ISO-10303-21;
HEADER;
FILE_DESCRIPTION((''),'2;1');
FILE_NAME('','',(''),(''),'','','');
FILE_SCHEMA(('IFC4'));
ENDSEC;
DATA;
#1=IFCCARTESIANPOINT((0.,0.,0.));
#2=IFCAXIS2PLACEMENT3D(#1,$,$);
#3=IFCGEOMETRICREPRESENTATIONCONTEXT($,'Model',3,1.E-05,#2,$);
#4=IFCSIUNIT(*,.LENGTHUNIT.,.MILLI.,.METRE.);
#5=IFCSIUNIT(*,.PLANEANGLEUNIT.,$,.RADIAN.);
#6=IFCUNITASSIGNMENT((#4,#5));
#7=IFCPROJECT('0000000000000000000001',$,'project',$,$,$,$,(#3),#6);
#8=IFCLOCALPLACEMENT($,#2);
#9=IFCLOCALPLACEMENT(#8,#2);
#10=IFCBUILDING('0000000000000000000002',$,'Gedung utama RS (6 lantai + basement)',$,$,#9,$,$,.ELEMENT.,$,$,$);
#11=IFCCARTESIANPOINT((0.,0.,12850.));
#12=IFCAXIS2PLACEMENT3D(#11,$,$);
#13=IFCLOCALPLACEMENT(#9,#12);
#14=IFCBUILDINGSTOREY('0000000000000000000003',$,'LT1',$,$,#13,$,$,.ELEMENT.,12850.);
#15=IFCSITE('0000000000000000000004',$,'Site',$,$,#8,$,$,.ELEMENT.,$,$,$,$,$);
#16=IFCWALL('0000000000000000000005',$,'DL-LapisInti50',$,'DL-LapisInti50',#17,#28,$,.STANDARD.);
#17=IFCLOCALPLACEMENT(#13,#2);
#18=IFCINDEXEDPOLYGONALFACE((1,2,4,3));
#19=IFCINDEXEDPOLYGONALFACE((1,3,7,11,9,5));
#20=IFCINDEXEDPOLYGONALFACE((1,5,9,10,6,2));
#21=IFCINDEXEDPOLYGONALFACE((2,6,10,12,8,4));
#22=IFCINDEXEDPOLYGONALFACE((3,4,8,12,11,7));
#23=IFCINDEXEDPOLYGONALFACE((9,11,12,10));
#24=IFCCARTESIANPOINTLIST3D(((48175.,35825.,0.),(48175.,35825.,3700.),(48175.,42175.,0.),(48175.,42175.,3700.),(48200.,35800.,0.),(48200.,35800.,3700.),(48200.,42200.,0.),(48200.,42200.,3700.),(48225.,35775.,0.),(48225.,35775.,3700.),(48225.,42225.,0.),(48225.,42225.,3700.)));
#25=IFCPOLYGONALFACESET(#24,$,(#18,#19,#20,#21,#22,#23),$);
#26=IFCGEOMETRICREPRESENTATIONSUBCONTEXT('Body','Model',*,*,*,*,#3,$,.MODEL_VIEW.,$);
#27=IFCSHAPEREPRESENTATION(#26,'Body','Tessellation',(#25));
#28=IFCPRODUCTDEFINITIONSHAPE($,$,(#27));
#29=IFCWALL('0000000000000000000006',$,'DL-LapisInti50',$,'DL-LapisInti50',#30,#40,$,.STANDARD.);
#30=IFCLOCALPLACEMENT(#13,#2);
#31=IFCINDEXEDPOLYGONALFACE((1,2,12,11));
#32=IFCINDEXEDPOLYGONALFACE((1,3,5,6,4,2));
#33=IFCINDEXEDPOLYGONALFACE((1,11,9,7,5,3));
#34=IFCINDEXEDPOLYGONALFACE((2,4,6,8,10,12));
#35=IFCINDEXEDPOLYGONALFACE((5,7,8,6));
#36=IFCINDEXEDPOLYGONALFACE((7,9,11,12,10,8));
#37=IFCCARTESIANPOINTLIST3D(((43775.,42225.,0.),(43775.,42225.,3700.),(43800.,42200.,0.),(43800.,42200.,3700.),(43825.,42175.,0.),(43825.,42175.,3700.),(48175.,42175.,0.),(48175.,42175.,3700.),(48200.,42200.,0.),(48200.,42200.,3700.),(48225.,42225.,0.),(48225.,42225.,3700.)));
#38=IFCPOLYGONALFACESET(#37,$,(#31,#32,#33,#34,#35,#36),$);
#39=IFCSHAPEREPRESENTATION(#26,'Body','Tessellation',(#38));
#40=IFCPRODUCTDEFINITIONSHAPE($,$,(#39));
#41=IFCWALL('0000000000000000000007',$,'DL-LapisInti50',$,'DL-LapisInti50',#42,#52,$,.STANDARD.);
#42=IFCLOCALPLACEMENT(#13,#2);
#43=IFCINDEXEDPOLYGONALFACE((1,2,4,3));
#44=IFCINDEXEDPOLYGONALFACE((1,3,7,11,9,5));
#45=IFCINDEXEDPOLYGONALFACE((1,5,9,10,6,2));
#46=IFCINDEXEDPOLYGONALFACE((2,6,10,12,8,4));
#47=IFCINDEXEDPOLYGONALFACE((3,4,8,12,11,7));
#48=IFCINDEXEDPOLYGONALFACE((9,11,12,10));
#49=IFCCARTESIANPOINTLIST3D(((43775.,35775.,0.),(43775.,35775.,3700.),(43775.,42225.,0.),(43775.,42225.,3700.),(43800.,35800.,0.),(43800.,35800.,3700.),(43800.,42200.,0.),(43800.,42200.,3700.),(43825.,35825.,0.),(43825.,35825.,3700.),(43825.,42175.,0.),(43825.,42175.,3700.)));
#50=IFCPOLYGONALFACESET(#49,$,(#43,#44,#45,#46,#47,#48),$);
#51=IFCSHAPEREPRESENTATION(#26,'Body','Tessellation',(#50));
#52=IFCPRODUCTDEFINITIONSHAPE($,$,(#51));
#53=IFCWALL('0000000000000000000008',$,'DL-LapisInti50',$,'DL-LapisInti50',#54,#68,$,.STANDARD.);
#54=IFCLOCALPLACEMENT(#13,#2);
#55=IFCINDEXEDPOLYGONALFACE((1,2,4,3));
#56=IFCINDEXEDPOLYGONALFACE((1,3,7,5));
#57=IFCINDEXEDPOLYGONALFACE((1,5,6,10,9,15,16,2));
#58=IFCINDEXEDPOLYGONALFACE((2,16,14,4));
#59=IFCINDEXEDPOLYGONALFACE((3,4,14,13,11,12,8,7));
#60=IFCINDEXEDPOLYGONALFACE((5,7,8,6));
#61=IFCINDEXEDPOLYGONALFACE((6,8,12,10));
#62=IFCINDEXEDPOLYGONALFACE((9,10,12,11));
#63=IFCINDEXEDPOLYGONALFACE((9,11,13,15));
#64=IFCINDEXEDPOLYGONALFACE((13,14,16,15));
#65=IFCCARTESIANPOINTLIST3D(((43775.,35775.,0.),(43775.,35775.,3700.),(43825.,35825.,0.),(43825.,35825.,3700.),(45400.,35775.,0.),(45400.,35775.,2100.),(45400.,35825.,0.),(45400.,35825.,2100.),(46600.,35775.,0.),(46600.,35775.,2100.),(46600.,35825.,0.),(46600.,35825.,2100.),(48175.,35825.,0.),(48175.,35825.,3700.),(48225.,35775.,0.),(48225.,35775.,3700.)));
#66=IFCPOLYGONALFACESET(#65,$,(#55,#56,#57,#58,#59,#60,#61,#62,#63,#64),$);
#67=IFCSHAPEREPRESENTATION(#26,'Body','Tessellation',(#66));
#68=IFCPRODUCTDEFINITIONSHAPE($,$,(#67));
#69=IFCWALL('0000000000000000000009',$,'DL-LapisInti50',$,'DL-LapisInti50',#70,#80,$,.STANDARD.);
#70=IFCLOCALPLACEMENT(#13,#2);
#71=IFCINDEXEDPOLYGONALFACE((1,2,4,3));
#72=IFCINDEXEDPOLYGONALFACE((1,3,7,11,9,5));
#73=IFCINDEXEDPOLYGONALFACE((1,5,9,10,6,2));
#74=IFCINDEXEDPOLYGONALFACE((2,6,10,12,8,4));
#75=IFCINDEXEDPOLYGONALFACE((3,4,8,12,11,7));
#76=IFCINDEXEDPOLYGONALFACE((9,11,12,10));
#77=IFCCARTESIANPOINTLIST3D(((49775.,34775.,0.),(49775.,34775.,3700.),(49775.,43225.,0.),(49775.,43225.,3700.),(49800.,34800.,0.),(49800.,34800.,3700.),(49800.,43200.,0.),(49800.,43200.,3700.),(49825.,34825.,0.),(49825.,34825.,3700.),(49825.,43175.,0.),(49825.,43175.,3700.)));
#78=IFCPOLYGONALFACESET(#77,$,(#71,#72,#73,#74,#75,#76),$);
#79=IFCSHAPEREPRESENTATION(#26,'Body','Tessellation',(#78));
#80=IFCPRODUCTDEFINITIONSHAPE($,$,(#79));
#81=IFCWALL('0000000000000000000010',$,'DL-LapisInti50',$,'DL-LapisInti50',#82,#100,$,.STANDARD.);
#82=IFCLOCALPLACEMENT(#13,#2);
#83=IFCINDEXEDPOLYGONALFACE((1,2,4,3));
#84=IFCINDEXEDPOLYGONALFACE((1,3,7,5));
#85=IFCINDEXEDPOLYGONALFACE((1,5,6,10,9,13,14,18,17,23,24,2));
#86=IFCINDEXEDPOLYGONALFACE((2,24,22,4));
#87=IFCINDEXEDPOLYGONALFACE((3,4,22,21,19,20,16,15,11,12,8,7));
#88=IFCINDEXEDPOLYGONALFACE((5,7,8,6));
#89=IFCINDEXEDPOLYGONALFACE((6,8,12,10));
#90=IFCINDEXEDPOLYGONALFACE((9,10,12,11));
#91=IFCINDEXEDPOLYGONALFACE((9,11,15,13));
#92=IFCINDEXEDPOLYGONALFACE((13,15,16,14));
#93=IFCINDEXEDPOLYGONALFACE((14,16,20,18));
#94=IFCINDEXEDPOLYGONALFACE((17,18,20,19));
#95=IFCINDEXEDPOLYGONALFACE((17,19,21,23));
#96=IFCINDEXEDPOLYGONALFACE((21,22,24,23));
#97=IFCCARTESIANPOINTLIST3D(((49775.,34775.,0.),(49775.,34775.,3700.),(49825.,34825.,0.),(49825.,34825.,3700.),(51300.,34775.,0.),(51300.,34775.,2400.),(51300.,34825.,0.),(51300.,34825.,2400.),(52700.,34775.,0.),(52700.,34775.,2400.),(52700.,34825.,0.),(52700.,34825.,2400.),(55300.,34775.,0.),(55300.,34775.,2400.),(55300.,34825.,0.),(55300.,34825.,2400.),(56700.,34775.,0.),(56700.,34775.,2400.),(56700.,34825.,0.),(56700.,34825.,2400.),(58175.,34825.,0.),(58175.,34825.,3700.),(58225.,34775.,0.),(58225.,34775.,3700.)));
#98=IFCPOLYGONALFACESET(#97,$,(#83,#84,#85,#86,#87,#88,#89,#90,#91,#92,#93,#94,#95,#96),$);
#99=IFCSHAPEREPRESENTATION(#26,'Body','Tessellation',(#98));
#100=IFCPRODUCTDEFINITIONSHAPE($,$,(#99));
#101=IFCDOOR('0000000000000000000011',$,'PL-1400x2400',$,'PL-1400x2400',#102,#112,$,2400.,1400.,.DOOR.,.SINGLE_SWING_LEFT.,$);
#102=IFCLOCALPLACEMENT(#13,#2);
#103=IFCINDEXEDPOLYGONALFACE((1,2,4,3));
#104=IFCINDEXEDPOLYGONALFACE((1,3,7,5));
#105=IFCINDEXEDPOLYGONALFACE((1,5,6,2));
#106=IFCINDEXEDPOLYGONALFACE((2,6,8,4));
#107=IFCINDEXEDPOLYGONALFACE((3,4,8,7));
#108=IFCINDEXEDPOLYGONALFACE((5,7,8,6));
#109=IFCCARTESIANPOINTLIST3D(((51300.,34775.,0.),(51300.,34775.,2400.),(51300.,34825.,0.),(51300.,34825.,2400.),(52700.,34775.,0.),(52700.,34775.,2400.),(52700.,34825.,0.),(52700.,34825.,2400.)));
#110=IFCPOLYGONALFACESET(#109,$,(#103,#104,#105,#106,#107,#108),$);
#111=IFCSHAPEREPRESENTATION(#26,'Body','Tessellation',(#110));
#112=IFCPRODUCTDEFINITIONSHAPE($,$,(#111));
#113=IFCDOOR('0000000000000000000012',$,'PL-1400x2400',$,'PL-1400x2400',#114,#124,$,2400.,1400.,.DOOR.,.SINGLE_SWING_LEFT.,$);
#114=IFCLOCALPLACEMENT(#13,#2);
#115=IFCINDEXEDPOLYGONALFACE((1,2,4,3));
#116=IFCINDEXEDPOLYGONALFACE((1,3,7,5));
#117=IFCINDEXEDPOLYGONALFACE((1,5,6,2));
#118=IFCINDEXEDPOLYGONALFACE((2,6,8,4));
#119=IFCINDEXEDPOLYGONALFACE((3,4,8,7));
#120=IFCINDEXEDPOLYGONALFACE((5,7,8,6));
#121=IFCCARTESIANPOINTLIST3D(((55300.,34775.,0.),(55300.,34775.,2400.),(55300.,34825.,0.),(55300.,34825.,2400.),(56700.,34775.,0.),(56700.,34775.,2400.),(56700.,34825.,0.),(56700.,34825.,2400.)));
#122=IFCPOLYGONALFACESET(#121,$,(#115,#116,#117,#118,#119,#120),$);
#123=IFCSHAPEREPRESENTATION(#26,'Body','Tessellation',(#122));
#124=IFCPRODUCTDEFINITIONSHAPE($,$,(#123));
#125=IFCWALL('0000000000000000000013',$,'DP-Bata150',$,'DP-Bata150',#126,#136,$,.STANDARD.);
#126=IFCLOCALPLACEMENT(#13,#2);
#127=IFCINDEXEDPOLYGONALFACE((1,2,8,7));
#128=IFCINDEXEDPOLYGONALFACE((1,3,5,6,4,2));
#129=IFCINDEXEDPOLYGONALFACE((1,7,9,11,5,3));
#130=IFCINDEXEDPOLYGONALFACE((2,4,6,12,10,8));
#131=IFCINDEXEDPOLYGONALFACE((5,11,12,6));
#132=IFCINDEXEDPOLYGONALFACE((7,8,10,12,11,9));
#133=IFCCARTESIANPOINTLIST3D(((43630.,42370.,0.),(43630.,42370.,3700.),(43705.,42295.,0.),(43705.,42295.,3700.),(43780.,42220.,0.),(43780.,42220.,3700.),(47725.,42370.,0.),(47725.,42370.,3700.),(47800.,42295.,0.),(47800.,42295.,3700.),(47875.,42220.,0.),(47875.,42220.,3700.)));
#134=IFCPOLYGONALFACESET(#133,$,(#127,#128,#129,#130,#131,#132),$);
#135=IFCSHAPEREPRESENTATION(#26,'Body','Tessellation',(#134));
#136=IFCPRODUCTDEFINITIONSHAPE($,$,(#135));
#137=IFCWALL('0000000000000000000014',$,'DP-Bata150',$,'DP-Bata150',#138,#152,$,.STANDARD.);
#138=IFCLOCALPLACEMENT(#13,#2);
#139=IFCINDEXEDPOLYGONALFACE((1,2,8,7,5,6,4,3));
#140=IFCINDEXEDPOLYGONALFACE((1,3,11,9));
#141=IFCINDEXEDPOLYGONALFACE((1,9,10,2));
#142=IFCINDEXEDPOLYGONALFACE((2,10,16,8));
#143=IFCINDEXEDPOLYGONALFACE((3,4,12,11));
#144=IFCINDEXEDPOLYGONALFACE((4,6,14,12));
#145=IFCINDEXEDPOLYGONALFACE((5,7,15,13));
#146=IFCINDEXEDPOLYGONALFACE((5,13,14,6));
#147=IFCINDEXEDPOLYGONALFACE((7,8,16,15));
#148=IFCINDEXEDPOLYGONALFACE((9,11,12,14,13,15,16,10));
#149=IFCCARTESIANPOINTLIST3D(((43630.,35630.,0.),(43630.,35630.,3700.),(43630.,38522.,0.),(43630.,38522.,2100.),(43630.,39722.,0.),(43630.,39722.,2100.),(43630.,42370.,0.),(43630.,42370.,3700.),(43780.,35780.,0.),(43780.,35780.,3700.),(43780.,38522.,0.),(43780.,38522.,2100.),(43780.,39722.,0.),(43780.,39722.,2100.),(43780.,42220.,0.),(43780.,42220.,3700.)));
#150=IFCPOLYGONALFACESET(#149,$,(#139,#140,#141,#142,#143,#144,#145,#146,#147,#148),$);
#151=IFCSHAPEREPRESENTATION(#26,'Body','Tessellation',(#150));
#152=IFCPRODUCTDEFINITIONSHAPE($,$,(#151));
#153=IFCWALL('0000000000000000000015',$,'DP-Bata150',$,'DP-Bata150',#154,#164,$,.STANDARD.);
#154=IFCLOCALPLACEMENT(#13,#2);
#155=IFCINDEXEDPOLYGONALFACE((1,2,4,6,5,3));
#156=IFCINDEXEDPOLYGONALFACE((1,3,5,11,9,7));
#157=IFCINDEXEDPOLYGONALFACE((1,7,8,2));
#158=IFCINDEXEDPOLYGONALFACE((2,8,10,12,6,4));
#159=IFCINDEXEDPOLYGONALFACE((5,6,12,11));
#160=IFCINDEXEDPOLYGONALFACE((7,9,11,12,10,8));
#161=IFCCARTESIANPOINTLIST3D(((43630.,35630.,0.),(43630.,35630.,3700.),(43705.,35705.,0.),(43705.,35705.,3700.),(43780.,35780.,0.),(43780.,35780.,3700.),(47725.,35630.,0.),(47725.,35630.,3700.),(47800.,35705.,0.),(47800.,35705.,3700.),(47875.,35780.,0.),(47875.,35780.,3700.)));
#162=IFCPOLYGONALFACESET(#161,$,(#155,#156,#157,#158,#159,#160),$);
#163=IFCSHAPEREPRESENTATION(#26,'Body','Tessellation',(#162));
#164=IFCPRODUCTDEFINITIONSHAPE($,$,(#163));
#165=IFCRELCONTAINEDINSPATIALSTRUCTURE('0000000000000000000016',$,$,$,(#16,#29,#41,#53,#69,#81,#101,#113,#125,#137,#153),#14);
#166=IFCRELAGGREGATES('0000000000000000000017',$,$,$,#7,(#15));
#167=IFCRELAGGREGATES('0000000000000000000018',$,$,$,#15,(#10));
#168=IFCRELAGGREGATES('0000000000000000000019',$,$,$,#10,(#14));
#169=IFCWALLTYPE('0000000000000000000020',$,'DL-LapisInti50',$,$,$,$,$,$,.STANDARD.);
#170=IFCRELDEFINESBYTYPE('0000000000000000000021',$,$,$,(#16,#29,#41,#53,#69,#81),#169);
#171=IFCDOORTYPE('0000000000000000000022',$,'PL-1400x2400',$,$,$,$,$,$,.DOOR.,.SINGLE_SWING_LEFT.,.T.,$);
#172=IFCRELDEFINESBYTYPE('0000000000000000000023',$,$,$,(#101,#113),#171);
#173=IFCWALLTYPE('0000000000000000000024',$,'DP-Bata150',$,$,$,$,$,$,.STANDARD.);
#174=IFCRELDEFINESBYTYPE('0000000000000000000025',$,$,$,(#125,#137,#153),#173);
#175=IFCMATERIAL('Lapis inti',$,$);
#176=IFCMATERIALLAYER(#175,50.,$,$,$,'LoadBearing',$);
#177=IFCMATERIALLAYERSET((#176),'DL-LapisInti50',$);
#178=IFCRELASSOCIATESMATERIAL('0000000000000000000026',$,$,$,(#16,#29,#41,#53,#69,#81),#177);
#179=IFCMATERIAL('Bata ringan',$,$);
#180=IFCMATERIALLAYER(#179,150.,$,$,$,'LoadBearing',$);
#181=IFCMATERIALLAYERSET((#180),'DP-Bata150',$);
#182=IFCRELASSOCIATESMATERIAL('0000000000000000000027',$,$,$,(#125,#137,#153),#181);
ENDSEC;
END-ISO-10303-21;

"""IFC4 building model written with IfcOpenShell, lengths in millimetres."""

from ifc_helpers import new_model, si_unit, frame, frame_2d, origin, place, context, subcontext, project, spatial, polyline, rectangle, outline, extrude, material, layer, layer_set, layer_usage, type_object, element, fill, save


model = new_model("IFC4")

# Units and contexts
model_context = context("Model", 3, precision=1e-05, world=origin())
body_context = subcontext(model_context, "Body", "Model", "MODEL_VIEW")
ifc_project = project(units=[si_unit("LENGTHUNIT", "METRE", prefix="MILLI"), si_unit("PLANEANGLEUNIT", "RADIAN")], contexts=[model_context])

# Site, building, storey
site_placement = place(None, origin())
site = spatial("IfcSite", under=ifc_project, at=site_placement, Name="Site", CompositionType="ELEMENT")
building_placement = place(site_placement, origin())
building = spatial("IfcBuilding", under=site, at=building_placement, Name="Gedung utama RS (6 lantai + basement)", CompositionType="ELEMENT")
storey_placement = place(building_placement, frame((0.0, 0.0, 12850.0)))
storey = spatial("IfcBuildingStorey", under=building, at=storey_placement, Name="LT1", CompositionType="ELEMENT", Elevation=12850.0)

# Walls
ifc_material_1 = material(Name="Lapis inti")
ifc_layer_1 = layer(ifc_material_1, 50.0, Category="LoadBearing")
ifc_layer_set_1 = layer_set([ifc_layer_1], Name="DL-LapisInti50")
ifc_layer_usage_1 = layer_usage(ifc_layer_set_1, "AXIS2", "NEGATIVE", 25.0)
wall_type_1 = type_object("IfcWallType", Name="DL-LapisInti50", PredefinedType="STANDARD")
wall_1_placement = place(storey_placement, frame((48200.0, 35800.0, 0.0), z_axis=(0.0, 0.0, 1.0), x_axis=(0.0, 1.0, 0.0)))
element("IfcWall", 1, at=wall_1_placement, inside=storey, type_object=wall_type_1, material=ifc_layer_usage_1, Name="DL-LapisInti50", ObjectType="DL-LapisInti50", PredefinedType="STANDARD", context=body_context, shape_type="SweptSolid", body=[
    extrude(outline(polyline([(-25.0, -25.0), (0.0, 0.0), (25.0, 25.0), (6375.0, 25.0), (6400.0, 0.0), (6425.0, -25.0), (-25.0, -25.0)])), origin(), (0.0, 0.0, 1.0), 3700.0),
])
wall_2_placement = place(storey_placement, frame((48200.0, 42200.0, 0.0), z_axis=(0.0, 0.0, 1.0), x_axis=(-1.0, 0.0, 0.0)))
element("IfcWall", 2, at=wall_2_placement, inside=storey, type_object=wall_type_1, material=ifc_layer_usage_1, Name="DL-LapisInti50", ObjectType="DL-LapisInti50", PredefinedType="STANDARD", context=body_context, shape_type="SweptSolid", body=[
    extrude(outline(polyline([(-25.0, -25.0), (0.0, 0.0), (25.0, 25.0), (4375.0, 25.0), (4400.0, 0.0), (4425.0, -25.0), (-25.0, -25.0)])), origin(), (0.0, 0.0, 1.0), 3700.0),
])
wall_3_placement = place(storey_placement, frame((43800.0, 42200.0, 0.0), z_axis=(0.0, 0.0, 1.0), x_axis=(0.0, -1.0, 0.0)))
element("IfcWall", 3, at=wall_3_placement, inside=storey, type_object=wall_type_1, material=ifc_layer_usage_1, Name="DL-LapisInti50", ObjectType="DL-LapisInti50", PredefinedType="STANDARD", context=body_context, shape_type="SweptSolid", body=[
    extrude(outline(polyline([(-25.0, -25.0), (0.0, 0.0), (25.0, 25.0), (6375.0, 25.0), (6400.0, 0.0), (6425.0, -25.0), (-25.0, -25.0)])), origin(), (0.0, 0.0, 1.0), 3700.0),
])

# Wall, opening
wall_4_placement = place(storey_placement, frame((43800.0, 35800.0, 0.0), z_axis=(0.0, 0.0, 1.0), x_axis=(1.0, 0.0, 0.0)))
wall_4 = element("IfcWall", 4, at=wall_4_placement, inside=storey, type_object=wall_type_1, material=ifc_layer_usage_1, Name="DL-LapisInti50", ObjectType="DL-LapisInti50", PredefinedType="STANDARD", context=body_context, shape_type="SweptSolid", body=[
    extrude(outline(polyline([(-25.0, -25.0), (0.0, 0.0), (25.0, 25.0), (4375.0, 25.0), (4400.0, 0.0), (4425.0, -25.0), (-25.0, -25.0)])), origin(), (0.0, 0.0, 1.0), 3700.0),
])
opening_1_placement = place(wall_4_placement, frame((1600.0, 0.0, 0.0), z_axis=(0.0, 0.0, 1.0), x_axis=(1.0, 0.0, 0.0)))
element("IfcOpeningElement", 5, at=opening_1_placement, cuts=wall_4, PredefinedType="OPENING", context=body_context, shape_type="SweptSolid", body=[
    extrude(rectangle(XDim=1200.0, YDim=70.0, at=frame_2d((600.0, 0.0))), origin(), (0.0, 0.0, 1.0), 2100.0),
])

# Wall
wall_5_placement = place(storey_placement, frame((49800.0, 43200.0, 0.0), z_axis=(0.0, 0.0, 1.0), x_axis=(0.0, -1.0, 0.0)))
element("IfcWall", 6, at=wall_5_placement, inside=storey, type_object=wall_type_1, material=ifc_layer_usage_1, Name="DL-LapisInti50", ObjectType="DL-LapisInti50", PredefinedType="STANDARD", context=body_context, shape_type="SweptSolid", body=[
    extrude(outline(polyline([(-25.0, -25.0), (0.0, 0.0), (25.0, 25.0), (8375.0, 25.0), (8400.0, 0.0), (8425.0, -25.0), (-25.0, -25.0)])), origin(), (0.0, 0.0, 1.0), 3700.0),
])

# Wall, openings, doors
wall_6_placement = place(storey_placement, frame((49800.0, 34800.0, 0.0), z_axis=(0.0, 0.0, 1.0), x_axis=(1.0, 0.0, 0.0)))
wall_6 = element("IfcWall", 7, at=wall_6_placement, inside=storey, type_object=wall_type_1, material=ifc_layer_usage_1, Name="DL-LapisInti50", ObjectType="DL-LapisInti50", PredefinedType="STANDARD", context=body_context, shape_type="SweptSolid", body=[
    extrude(outline(polyline([(-25.0, -25.0), (0.0, 0.0), (25.0, 25.0), (8375.0, 25.0), (8400.0, 0.0), (8425.0, -25.0), (-25.0, -25.0)])), origin(), (0.0, 0.0, 1.0), 3700.0),
])
opening_2_placement = place(wall_6_placement, frame((1500.0, 0.0, 0.0), z_axis=(0.0, 0.0, 1.0), x_axis=(1.0, 0.0, 0.0)))
opening_2 = element("IfcOpeningElement", 8, at=opening_2_placement, cuts=wall_6, PredefinedType="OPENING", context=body_context, shape_type="SweptSolid", body=[
    extrude(rectangle(XDim=1400.0, YDim=70.0, at=frame_2d((700.0, 0.0))), origin(), (0.0, 0.0, 1.0), 2400.0),
])
opening_3_placement = place(wall_6_placement, frame((5500.0, 0.0, 0.0), z_axis=(0.0, 0.0, 1.0), x_axis=(1.0, 0.0, 0.0)))
opening_3 = element("IfcOpeningElement", 9, at=opening_3_placement, cuts=wall_6, PredefinedType="OPENING", context=body_context, shape_type="SweptSolid", body=[
    extrude(rectangle(XDim=1400.0, YDim=70.0, at=frame_2d((700.0, 0.0))), origin(), (0.0, 0.0, 1.0), 2400.0),
])
door_type = type_object("IfcDoorType", Name="PL-1400x2400", OperationType="SINGLE_SWING_LEFT", ParameterTakesPrecedence=True, PredefinedType="DOOR")
door_1_placement = place(opening_2_placement, origin())
door_1 = element("IfcDoor", 10, at=door_1_placement, inside=storey, type_object=door_type, Name="PL-1400x2400", ObjectType="PL-1400x2400", OperationType="SINGLE_SWING_LEFT", OverallHeight=2400.0, OverallWidth=1400.0, PredefinedType="DOOR", context=body_context, shape_type="SweptSolid", body=[
    extrude(rectangle(XDim=1400.0, YDim=50.0, at=frame_2d((700.0, 0.0))), origin(), (0.0, 0.0, 1.0), 2400.0),
])
fill(opening_2, door_1)
door_2_placement = place(opening_3_placement, origin())
door_2 = element("IfcDoor", 11, at=door_2_placement, inside=storey, type_object=door_type, Name="PL-1400x2400", ObjectType="PL-1400x2400", OperationType="SINGLE_SWING_LEFT", OverallHeight=2400.0, OverallWidth=1400.0, PredefinedType="DOOR", context=body_context, shape_type="SweptSolid", body=[
    extrude(rectangle(XDim=1400.0, YDim=50.0, at=frame_2d((700.0, 0.0))), origin(), (0.0, 0.0, 1.0), 2400.0),
])
fill(opening_3, door_2)

# Wall
ifc_material_2 = material(Name="Bata ringan")
ifc_layer_2 = layer(ifc_material_2, 150.0, Category="LoadBearing")
ifc_layer_set_2 = layer_set([ifc_layer_2], Name="DP-Bata150")
ifc_layer_usage_2 = layer_usage(ifc_layer_set_2, "AXIS2", "NEGATIVE", 75.0)
wall_type_2 = type_object("IfcWallType", Name="DP-Bata150", PredefinedType="STANDARD")
wall_7_placement = place(storey_placement, frame((47800.0, 42295.0, 0.0), z_axis=(0.0, 0.0, 1.0), x_axis=(-1.0, 0.0, 0.0)))
element("IfcWall", 12, at=wall_7_placement, inside=storey, type_object=wall_type_2, material=ifc_layer_usage_2, Name="DP-Bata150", ObjectType="DP-Bata150", PredefinedType="STANDARD", context=body_context, shape_type="SweptSolid", body=[
    extrude(outline(polyline([(75.0, -75.0), (0.0, 0.0), (-75.0, 75.0), (4020.0, 75.0), (4095.0, 0.0), (4170.0, -75.0), (75.0, -75.0)])), origin(), (0.0, 0.0, 1.0), 3700.0),
])

# Wall, opening
wall_8_placement = place(storey_placement, frame((43705.0, 42295.0, 0.0), z_axis=(0.0, 0.0, 1.0), x_axis=(0.0, -1.0, 0.0)))
wall_8 = element("IfcWall", 13, at=wall_8_placement, inside=storey, type_object=wall_type_2, material=ifc_layer_usage_2, Name="DP-Bata150", ObjectType="DP-Bata150", PredefinedType="STANDARD", context=body_context, shape_type="SweptSolid", body=[
    extrude(outline(polyline([(-75.0, -75.0), (0.0, 0.0), (75.0, 75.0), (6515.0, 75.0), (6590.0, 0.0), (6665.0, -75.0), (-75.0, -75.0)])), origin(), (0.0, 0.0, 1.0), 3700.0),
])
opening_4_placement = place(wall_8_placement, frame((2573.0, 0.0, 0.0), z_axis=(0.0, 0.0, 1.0), x_axis=(1.0, 0.0, 0.0)))
element("IfcOpeningElement", 14, at=opening_4_placement, cuts=wall_8, PredefinedType="OPENING", context=body_context, shape_type="SweptSolid", body=[
    extrude(rectangle(XDim=1200.0, YDim=170.0, at=frame_2d((600.0, 0.0))), origin(), (0.0, 0.0, 1.0), 2100.0),
])

# Wall
wall_9_placement = place(storey_placement, frame((43705.0, 35705.0, 0.0), z_axis=(0.0, 0.0, 1.0), x_axis=(1.0, 0.0, 0.0)))
element("IfcWall", 15, at=wall_9_placement, inside=storey, type_object=wall_type_2, material=ifc_layer_usage_2, Name="DP-Bata150", ObjectType="DP-Bata150", PredefinedType="STANDARD", context=body_context, shape_type="SweptSolid", body=[
    extrude(outline(polyline([(-75.0, -75.0), (0.0, 0.0), (75.0, 75.0), (4170.0, 75.0), (4095.0, 0.0), (4020.0, -75.0), (-75.0, -75.0)])), origin(), (0.0, 0.0, 1.0), 3700.0),
])

save(model, "model.ifc")
